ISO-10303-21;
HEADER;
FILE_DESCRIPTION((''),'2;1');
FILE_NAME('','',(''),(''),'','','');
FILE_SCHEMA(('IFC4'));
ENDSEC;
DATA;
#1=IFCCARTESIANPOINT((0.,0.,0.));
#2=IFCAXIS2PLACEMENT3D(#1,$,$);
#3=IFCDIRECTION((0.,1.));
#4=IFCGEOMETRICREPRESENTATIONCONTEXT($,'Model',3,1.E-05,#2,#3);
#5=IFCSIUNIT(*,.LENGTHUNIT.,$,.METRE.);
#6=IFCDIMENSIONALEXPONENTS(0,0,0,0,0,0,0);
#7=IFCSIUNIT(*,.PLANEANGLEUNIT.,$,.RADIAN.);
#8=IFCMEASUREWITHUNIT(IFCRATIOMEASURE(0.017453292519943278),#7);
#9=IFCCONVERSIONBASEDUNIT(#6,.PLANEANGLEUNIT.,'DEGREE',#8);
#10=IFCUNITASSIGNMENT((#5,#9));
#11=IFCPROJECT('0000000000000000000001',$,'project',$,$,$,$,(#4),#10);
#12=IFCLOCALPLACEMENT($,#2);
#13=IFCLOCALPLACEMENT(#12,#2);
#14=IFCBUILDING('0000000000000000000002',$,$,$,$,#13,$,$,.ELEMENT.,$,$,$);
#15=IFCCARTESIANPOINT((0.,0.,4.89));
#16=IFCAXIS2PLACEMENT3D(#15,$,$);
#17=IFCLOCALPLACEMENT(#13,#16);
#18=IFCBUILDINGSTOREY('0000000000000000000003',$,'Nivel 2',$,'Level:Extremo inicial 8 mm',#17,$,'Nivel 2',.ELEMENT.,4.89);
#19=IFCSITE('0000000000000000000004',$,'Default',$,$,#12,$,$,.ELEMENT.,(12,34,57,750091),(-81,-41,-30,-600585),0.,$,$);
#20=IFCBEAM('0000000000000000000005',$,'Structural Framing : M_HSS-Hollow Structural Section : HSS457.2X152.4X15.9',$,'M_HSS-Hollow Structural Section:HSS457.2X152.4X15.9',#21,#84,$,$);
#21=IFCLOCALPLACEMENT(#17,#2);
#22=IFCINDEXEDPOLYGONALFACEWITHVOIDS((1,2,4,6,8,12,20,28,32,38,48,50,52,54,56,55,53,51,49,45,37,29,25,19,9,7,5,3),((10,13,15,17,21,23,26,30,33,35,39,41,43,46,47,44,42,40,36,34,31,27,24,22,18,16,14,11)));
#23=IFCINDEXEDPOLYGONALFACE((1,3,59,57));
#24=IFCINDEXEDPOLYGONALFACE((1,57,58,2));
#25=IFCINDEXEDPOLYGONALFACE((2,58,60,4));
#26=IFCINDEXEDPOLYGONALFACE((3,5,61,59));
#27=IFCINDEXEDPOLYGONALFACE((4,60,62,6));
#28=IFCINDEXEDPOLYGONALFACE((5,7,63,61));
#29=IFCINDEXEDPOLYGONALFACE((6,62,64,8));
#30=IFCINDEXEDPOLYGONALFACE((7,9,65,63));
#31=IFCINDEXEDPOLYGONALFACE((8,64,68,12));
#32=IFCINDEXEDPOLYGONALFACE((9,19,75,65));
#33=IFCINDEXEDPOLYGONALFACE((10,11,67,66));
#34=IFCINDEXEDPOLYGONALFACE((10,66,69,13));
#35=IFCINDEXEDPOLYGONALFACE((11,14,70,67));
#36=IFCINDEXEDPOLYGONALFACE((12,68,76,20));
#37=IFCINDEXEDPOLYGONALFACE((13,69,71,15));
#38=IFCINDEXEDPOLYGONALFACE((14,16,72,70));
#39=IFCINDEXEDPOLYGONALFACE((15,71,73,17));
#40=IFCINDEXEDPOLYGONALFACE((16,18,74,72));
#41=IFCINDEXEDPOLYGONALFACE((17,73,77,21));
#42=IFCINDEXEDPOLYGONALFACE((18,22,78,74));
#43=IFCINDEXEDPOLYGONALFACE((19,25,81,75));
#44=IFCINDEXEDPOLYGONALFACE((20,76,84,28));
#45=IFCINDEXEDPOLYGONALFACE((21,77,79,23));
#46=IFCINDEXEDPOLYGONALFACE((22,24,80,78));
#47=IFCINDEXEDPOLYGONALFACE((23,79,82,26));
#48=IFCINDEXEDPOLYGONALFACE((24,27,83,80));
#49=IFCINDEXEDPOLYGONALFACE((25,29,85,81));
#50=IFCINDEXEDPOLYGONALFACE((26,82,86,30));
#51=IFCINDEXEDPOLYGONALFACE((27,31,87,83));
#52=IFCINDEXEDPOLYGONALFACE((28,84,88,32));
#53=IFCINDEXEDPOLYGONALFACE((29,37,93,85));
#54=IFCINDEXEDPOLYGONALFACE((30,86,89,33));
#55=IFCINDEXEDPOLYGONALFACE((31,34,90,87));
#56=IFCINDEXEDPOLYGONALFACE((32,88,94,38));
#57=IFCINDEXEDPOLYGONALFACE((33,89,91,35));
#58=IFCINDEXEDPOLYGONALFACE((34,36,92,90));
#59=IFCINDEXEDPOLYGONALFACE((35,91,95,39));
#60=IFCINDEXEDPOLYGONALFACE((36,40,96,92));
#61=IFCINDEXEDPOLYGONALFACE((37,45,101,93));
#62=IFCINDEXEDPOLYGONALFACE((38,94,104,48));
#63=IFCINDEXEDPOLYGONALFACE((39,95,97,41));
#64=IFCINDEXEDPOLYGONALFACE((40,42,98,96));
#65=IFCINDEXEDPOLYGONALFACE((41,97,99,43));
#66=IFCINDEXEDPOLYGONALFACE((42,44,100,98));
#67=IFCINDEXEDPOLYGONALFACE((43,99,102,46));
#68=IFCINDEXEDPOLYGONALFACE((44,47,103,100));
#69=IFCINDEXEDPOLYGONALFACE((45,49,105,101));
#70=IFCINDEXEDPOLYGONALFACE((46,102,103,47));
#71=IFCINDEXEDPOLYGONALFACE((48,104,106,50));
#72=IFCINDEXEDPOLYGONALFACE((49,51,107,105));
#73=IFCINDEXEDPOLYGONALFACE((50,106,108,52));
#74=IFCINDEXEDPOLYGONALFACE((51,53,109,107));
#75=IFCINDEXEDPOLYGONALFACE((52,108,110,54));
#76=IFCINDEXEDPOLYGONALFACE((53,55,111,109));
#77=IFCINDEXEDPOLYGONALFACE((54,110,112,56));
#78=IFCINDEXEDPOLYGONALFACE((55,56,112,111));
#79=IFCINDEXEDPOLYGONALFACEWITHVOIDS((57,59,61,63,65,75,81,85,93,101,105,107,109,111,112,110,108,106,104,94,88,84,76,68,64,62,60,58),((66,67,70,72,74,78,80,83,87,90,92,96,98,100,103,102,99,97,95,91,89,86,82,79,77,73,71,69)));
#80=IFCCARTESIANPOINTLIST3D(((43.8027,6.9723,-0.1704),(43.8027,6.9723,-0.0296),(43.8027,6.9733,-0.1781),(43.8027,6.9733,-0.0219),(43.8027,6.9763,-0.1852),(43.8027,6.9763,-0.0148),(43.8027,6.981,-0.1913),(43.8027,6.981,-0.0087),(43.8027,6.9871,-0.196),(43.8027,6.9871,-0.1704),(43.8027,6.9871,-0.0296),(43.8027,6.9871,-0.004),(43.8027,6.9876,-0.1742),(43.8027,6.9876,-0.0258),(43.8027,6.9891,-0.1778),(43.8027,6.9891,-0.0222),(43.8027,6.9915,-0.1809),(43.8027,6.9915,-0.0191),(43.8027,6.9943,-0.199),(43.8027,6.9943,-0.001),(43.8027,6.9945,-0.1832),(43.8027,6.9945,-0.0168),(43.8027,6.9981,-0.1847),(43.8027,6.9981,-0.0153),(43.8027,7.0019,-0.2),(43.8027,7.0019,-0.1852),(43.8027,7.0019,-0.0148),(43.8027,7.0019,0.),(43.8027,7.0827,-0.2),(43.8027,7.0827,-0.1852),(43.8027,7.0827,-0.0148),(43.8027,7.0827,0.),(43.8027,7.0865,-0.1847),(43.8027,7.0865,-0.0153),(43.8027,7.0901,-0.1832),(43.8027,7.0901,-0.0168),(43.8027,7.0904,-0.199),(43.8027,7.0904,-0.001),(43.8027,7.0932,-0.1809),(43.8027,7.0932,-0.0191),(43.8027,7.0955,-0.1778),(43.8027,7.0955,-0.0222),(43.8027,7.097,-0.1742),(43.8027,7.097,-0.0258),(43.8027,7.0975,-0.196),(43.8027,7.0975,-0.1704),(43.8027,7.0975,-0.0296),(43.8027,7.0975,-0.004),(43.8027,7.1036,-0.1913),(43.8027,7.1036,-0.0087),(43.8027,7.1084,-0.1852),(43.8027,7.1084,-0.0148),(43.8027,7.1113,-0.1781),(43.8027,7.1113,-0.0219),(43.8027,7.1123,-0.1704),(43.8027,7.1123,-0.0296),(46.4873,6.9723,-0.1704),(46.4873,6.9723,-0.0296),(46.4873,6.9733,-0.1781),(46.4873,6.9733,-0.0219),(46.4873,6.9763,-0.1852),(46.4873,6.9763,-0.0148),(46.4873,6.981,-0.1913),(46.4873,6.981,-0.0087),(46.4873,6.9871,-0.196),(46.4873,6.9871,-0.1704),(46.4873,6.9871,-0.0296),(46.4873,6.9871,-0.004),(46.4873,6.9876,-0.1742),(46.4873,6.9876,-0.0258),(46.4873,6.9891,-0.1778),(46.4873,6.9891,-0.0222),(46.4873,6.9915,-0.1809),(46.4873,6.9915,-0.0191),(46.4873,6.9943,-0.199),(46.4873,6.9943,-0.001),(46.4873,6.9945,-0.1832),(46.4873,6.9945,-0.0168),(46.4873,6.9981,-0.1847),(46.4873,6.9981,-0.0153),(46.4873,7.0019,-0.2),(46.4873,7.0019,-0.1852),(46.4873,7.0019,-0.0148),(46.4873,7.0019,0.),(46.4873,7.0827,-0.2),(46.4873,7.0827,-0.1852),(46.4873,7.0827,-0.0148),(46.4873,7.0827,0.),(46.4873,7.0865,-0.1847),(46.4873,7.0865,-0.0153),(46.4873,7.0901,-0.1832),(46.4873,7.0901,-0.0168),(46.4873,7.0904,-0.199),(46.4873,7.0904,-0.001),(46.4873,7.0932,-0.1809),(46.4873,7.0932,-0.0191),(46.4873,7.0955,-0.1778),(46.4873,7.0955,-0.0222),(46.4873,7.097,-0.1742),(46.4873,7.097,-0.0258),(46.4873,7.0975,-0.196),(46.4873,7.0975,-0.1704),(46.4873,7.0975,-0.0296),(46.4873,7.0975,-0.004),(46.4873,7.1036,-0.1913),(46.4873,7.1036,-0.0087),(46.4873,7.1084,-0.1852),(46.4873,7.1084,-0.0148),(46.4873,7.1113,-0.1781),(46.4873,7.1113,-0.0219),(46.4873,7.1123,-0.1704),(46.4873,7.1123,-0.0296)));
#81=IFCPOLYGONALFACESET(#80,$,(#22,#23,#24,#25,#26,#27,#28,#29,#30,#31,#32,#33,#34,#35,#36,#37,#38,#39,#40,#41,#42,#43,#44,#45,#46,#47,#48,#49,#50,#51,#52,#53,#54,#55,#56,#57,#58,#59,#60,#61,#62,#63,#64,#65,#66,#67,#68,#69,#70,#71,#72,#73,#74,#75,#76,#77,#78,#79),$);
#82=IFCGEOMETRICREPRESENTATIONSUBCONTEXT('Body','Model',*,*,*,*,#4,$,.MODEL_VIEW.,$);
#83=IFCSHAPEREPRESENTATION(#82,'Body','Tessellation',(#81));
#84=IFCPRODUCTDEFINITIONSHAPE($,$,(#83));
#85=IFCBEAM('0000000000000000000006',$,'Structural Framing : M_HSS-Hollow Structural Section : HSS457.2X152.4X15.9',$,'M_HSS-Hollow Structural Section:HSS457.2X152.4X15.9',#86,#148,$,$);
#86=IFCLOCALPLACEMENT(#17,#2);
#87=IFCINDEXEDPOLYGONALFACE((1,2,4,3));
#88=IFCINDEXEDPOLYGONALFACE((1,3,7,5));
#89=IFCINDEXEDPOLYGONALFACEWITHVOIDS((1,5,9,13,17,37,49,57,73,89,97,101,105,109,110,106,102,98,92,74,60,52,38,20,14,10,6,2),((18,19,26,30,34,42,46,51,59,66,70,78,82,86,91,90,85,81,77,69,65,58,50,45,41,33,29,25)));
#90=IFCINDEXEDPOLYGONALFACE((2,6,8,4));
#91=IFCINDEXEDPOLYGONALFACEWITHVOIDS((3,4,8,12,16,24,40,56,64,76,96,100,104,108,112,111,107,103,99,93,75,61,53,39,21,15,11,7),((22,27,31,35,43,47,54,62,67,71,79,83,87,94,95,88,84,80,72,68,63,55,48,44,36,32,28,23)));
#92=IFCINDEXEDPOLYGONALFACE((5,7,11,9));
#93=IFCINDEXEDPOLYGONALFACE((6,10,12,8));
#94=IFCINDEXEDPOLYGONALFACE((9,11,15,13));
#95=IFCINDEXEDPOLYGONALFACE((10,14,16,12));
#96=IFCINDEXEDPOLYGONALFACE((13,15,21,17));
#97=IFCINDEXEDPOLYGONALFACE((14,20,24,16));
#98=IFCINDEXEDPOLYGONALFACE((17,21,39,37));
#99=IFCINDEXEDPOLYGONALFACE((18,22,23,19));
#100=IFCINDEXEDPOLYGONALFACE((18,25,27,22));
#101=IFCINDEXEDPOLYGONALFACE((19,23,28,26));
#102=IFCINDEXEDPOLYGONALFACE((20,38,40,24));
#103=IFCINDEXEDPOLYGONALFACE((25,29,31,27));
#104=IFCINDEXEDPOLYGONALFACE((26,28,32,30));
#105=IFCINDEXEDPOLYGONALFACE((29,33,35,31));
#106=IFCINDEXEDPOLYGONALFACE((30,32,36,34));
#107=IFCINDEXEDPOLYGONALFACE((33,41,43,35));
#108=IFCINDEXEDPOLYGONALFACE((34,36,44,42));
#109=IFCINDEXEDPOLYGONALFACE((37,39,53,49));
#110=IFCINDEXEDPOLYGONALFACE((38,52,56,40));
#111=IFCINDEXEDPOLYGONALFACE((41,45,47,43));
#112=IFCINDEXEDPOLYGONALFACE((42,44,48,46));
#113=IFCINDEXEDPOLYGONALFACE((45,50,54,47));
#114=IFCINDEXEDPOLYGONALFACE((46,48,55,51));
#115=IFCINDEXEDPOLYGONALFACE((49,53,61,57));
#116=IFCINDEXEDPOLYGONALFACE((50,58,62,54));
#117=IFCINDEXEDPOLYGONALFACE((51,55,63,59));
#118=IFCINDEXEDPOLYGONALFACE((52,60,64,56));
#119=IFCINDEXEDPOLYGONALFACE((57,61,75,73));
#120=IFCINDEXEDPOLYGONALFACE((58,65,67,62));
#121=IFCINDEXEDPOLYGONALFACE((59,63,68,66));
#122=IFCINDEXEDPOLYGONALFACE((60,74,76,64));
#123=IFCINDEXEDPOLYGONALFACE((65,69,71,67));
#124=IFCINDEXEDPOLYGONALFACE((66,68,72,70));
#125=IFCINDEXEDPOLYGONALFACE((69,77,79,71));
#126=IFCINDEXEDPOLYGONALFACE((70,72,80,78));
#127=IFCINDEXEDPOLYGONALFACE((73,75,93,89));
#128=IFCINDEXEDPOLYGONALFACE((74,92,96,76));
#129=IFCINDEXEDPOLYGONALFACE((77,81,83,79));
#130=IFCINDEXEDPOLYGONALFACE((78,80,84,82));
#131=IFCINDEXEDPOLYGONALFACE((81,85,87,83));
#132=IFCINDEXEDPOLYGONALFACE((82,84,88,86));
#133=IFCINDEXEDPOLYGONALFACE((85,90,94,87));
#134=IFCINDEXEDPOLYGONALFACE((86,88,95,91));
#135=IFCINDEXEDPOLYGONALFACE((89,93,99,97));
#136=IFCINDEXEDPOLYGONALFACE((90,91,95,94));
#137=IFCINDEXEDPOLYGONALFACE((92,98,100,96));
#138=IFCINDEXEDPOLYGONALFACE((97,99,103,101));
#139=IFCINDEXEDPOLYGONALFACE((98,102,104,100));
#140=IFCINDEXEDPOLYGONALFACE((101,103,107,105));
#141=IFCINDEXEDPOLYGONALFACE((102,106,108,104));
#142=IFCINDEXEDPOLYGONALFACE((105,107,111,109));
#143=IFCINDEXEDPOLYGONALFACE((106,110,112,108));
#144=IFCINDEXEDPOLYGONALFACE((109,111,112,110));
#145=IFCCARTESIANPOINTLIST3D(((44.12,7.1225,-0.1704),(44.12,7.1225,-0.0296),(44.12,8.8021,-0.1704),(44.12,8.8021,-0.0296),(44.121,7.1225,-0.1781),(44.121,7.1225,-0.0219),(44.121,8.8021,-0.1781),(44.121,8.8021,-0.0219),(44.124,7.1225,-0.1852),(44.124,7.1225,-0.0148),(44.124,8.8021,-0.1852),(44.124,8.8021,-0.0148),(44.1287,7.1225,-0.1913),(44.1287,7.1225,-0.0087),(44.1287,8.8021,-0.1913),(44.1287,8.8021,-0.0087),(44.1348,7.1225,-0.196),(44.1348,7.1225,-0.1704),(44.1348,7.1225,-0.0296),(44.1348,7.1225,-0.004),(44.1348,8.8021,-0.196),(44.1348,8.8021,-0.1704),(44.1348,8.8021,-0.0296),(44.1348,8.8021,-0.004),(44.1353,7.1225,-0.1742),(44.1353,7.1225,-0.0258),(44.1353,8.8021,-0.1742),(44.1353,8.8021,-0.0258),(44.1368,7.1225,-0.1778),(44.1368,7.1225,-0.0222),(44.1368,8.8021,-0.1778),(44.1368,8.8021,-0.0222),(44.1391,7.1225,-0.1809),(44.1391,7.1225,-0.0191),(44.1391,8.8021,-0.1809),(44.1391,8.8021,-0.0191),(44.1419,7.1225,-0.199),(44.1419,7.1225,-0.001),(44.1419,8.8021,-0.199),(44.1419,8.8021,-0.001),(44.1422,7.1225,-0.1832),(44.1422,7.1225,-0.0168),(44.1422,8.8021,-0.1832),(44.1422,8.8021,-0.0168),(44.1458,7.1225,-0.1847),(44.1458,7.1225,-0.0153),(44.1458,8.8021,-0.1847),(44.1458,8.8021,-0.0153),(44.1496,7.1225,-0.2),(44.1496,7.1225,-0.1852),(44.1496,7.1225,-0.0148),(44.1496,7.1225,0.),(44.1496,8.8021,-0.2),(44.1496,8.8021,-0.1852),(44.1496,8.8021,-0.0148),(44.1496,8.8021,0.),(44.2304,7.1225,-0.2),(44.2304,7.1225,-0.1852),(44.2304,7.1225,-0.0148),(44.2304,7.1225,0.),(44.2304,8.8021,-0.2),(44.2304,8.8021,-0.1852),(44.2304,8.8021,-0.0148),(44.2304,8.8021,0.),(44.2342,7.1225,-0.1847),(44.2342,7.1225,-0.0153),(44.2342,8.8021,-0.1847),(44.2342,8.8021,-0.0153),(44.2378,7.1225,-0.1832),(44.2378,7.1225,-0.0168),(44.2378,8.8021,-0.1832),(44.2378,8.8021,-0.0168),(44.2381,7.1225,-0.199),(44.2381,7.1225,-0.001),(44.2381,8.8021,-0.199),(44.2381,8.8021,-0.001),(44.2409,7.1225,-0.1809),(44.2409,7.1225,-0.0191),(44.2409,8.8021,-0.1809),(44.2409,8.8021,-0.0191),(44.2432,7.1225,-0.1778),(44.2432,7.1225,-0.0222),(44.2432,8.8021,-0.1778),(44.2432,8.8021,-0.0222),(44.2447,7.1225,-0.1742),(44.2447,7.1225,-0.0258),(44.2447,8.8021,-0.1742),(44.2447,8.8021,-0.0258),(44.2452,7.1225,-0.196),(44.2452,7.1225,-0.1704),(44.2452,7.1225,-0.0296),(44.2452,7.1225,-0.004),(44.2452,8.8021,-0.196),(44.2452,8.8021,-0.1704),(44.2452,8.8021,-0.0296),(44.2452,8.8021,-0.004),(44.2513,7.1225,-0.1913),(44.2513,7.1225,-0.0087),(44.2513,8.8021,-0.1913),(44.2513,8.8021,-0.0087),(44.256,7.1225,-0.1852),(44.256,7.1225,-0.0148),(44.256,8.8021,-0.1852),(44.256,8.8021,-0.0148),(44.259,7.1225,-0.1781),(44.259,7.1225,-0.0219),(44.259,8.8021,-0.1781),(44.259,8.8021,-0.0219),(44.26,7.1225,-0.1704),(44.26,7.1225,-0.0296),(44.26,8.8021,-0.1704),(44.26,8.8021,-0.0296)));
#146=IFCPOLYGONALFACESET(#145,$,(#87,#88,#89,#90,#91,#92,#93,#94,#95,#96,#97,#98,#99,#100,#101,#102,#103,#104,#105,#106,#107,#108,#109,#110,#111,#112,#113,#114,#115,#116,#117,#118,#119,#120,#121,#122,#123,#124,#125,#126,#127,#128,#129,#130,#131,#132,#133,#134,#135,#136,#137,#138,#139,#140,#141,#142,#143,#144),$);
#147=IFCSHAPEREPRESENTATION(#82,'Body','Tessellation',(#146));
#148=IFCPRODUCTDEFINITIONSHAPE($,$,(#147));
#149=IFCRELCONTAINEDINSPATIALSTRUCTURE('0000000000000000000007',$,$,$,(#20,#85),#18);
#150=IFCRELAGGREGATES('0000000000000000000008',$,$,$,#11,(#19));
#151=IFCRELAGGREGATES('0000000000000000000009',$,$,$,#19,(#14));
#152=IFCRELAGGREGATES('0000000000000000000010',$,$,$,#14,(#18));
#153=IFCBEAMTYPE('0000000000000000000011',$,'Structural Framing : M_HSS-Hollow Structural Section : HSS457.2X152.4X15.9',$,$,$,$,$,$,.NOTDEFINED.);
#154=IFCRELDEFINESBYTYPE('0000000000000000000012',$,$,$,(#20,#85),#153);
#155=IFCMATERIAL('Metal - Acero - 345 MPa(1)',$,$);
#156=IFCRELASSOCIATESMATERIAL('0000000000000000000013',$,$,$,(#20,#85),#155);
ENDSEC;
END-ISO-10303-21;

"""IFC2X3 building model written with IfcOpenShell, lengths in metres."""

from ifc_helpers import new_model, entity, si_unit, converted_unit, direction, frame, frame_2d, origin, place, context, subcontext, project, spatial, polyline, circle_curve, parameter, trimmed, segment, composite_curve, outline, extrude, material, type_object, element, save


model = new_model("IFC2X3")

# Units and contexts
model_context = context("Model", 3, precision=1e-05, world=origin(), true_north=direction((0.0, 1.0)))
body_context = subcontext(model_context, "Body", "Model", "MODEL_VIEW")
ifc_project = project(units=[si_unit("LENGTHUNIT", "METRE"), converted_unit("PLANEANGLEUNIT", "DEGREE", entity("IfcRatioMeasure", 0.017453292519943278), si_unit("PLANEANGLEUNIT", "RADIAN"), dimensions=[0, 0, 0, 0, 0, 0, 0])], contexts=[model_context])

# Site, building, storey
site_placement = place(None, origin())
site = spatial("IfcSite", under=ifc_project, at=site_placement, Name="Default", CompositionType="ELEMENT", RefLatitude=(12, 34, 57, 750091), RefLongitude=(-81, -41, -30, -600585), RefElevation=0.0)
building_placement = place(site_placement, origin())
building = spatial("IfcBuilding", under=site, at=building_placement, CompositionType="ELEMENT")
storey_placement = place(building_placement, frame((0.0, 0.0, 4.89)))
storey = spatial("IfcBuildingStorey", under=building, at=storey_placement, Name="Nivel 2", ObjectType="Level:Extremo inicial 8 mm", LongName="Nivel 2", CompositionType="ELEMENT", Elevation=4.89)

# Shared definitions
ifc_material_1 = material(Name="Metal - Acero - 345 MPa(1)")

# Beams
beam_type_1 = type_object("IfcBeamType", Name="Structural Framing : M_HSS-Hollow Structural Section : HSS457.2X152.4X15.9", PredefinedType="NOTDEFINED")
beam_1_placement = place(storey_placement, frame((43.74, 7.0423, 0.0)))
element("IfcBeam", 1, at=beam_1_placement, inside=storey, type_object=beam_type_1, material=ifc_material_1, Name="Structural Framing : M_HSS-Hollow Structural Section : HSS457.2X152.4X15.9", ObjectType="M_HSS-Hollow Structural Section:HSS457.2X152.4X15.9", context=body_context, shape_type="SweptSolid", body=[
    extrude(outline(composite_curve([segment(trimmed(circle_curve(frame_2d((-0.0404, -0.0704), x_axis=(1.0, 0.0)), 0.0296), [parameter(180.0)], [parameter(270.0)], True, "PARAMETER"), True, "CONTINUOUS"), segment(polyline([(-0.0404, -0.1), (0.0404, -0.1)]), True, "CONTINUOUS"), segment(trimmed(circle_curve(frame_2d((0.0404, -0.0704), x_axis=(1.0, 0.0)), 0.0296), [parameter(270.0)], [parameter(0.0)], True, "PARAMETER"), True, "CONTINUOUS"), segment(polyline([(0.07, -0.0704), (0.07, 0.0704)]), True, "CONTINUOUS"), segment(trimmed(circle_curve(frame_2d((0.0404, 0.0704), x_axis=(1.0, 0.0)), 0.0296), [parameter(360.0)], [parameter(90.0)], True, "PARAMETER"), True, "CONTINUOUS"), segment(polyline([(0.0404, 0.1), (-0.0404, 0.1)]), True, "CONTINUOUS"), segment(trimmed(circle_curve(frame_2d((-0.0404, 0.0704), x_axis=(1.0, 0.0)), 0.0296), [parameter(90.0)], [parameter(180.0)], True, "PARAMETER"), True, "CONTINUOUS"), segment(polyline([(-0.07, 0.0704), (-0.07, -0.0704)]), True, "CONTINUOUS")], self_intersect=False), holes=[composite_curve([segment(polyline([(0.0404, -0.0852), (-0.0404, -0.0852)]), True, "CONTINUOUS"), segment(trimmed(circle_curve(frame_2d((-0.0404, -0.0704), x_axis=(1.0, 0.0)), 0.0148), [parameter(180.0)], [parameter(270.0)], True, "PARAMETER"), False, "CONTINUOUS"), segment(polyline([(-0.0552, -0.0704), (-0.0552, 0.0704)]), True, "CONTINUOUS"), segment(trimmed(circle_curve(frame_2d((-0.0404, 0.0704), x_axis=(1.0, 0.0)), 0.0148), [parameter(90.0)], [parameter(180.0)], True, "PARAMETER"), False, "CONTINUOUS"), segment(polyline([(-0.0404, 0.0852), (0.0404, 0.0852)]), True, "CONTINUOUS"), segment(trimmed(circle_curve(frame_2d((0.0404, 0.0704), x_axis=(1.0, 0.0)), 0.0148), [parameter(0.0)], [parameter(90.0)], True, "PARAMETER"), False, "CONTINUOUS"), segment(polyline([(0.0552, 0.0704), (0.0552, -0.0704)]), True, "CONTINUOUS"), segment(trimmed(circle_curve(frame_2d((0.0404, -0.0704), x_axis=(1.0, 0.0)), 0.0148), [parameter(270.0)], [parameter(0.0)], True, "PARAMETER"), False, "CONTINUOUS")], self_intersect=False)]), frame((0.0627, 0.0, -0.1), z_axis=(1.0, 0.0, 0.0), x_axis=(0.0, -1.0, 0.0)), (0.0, 0.0, 1.0), 2.6846),
])
beam_2_placement = place(storey_placement, frame((44.19, 8.8823, 0.0), z_axis=(0.0, 0.0, 1.0), x_axis=(0.0, -1.0, 0.0)))
element("IfcBeam", 2, at=beam_2_placement, inside=storey, type_object=beam_type_1, material=ifc_material_1, Name="Structural Framing : M_HSS-Hollow Structural Section : HSS457.2X152.4X15.9", ObjectType="M_HSS-Hollow Structural Section:HSS457.2X152.4X15.9", context=body_context, shape_type="SweptSolid", body=[
    extrude(outline(composite_curve([segment(trimmed(circle_curve(frame_2d((0.0704, -0.0404), x_axis=(1.0, 0.0)), 0.0296), [parameter(270.0)], [parameter(360.0)], True, "PARAMETER"), True, "CONTINUOUS"), segment(polyline([(0.1, -0.0404), (0.1, 0.0404)]), True, "CONTINUOUS"), segment(trimmed(circle_curve(frame_2d((0.0704, 0.0404), x_axis=(0.0, 1.0)), 0.0296), [parameter(270.0)], [parameter(0.0)], True, "PARAMETER"), True, "CONTINUOUS"), segment(polyline([(0.0704, 0.07), (-0.0704, 0.07)]), True, "CONTINUOUS"), segment(trimmed(circle_curve(frame_2d((-0.0704, 0.0404), x_axis=(-1.0, 0.0)), 0.0296), [parameter(270.0)], [parameter(0.0)], True, "PARAMETER"), True, "CONTINUOUS"), segment(polyline([(-0.1, 0.0404), (-0.1, -0.0404)]), True, "CONTINUOUS"), segment(trimmed(circle_curve(frame_2d((-0.0704, -0.0404), x_axis=(0.0, -1.0)), 0.0296), [parameter(270.0)], [parameter(0.0)], True, "PARAMETER"), True, "CONTINUOUS"), segment(polyline([(-0.0704, -0.07), (0.0704, -0.07)]), True, "CONTINUOUS")], self_intersect=False), holes=[composite_curve([segment(polyline([(0.0852, 0.0404), (0.0852, -0.0404)]), True, "CONTINUOUS"), segment(trimmed(circle_curve(frame_2d((0.0704, -0.0404), x_axis=(0.0, -1.0)), 0.0148), [parameter(0.0)], [parameter(90.0)], True, "PARAMETER"), False, "CONTINUOUS"), segment(polyline([(0.0704, -0.0552), (-0.0704, -0.0552)]), True, "CONTINUOUS"), segment(trimmed(circle_curve(frame_2d((-0.0704, -0.0404), x_axis=(-1.0, 0.0)), 0.0148), [parameter(0.0)], [parameter(90.0)], True, "PARAMETER"), False, "CONTINUOUS"), segment(polyline([(-0.0852, -0.0404), (-0.0852, 0.0404)]), True, "CONTINUOUS"), segment(trimmed(circle_curve(frame_2d((-0.0704, 0.0404), x_axis=(0.0, 1.0)), 0.0148), [parameter(0.0)], [parameter(90.0)], True, "PARAMETER"), False, "CONTINUOUS"), segment(polyline([(-0.0704, 0.0552), (0.0704, 0.0552)]), True, "CONTINUOUS"), segment(trimmed(circle_curve(frame_2d((0.0704, 0.0404), x_axis=(1.0, 0.0)), 0.0148), [parameter(0.0)], [parameter(90.0)], True, "PARAMETER"), False, "CONTINUOUS")], self_intersect=False)]), frame((0.0802, 0.0, -0.1), z_axis=(1.0, 0.0, 0.0), x_axis=(0.0, 0.0, 1.0)), (0.0, 0.0, 1.0), 1.6796),
])

save(model, "model.ifc")
